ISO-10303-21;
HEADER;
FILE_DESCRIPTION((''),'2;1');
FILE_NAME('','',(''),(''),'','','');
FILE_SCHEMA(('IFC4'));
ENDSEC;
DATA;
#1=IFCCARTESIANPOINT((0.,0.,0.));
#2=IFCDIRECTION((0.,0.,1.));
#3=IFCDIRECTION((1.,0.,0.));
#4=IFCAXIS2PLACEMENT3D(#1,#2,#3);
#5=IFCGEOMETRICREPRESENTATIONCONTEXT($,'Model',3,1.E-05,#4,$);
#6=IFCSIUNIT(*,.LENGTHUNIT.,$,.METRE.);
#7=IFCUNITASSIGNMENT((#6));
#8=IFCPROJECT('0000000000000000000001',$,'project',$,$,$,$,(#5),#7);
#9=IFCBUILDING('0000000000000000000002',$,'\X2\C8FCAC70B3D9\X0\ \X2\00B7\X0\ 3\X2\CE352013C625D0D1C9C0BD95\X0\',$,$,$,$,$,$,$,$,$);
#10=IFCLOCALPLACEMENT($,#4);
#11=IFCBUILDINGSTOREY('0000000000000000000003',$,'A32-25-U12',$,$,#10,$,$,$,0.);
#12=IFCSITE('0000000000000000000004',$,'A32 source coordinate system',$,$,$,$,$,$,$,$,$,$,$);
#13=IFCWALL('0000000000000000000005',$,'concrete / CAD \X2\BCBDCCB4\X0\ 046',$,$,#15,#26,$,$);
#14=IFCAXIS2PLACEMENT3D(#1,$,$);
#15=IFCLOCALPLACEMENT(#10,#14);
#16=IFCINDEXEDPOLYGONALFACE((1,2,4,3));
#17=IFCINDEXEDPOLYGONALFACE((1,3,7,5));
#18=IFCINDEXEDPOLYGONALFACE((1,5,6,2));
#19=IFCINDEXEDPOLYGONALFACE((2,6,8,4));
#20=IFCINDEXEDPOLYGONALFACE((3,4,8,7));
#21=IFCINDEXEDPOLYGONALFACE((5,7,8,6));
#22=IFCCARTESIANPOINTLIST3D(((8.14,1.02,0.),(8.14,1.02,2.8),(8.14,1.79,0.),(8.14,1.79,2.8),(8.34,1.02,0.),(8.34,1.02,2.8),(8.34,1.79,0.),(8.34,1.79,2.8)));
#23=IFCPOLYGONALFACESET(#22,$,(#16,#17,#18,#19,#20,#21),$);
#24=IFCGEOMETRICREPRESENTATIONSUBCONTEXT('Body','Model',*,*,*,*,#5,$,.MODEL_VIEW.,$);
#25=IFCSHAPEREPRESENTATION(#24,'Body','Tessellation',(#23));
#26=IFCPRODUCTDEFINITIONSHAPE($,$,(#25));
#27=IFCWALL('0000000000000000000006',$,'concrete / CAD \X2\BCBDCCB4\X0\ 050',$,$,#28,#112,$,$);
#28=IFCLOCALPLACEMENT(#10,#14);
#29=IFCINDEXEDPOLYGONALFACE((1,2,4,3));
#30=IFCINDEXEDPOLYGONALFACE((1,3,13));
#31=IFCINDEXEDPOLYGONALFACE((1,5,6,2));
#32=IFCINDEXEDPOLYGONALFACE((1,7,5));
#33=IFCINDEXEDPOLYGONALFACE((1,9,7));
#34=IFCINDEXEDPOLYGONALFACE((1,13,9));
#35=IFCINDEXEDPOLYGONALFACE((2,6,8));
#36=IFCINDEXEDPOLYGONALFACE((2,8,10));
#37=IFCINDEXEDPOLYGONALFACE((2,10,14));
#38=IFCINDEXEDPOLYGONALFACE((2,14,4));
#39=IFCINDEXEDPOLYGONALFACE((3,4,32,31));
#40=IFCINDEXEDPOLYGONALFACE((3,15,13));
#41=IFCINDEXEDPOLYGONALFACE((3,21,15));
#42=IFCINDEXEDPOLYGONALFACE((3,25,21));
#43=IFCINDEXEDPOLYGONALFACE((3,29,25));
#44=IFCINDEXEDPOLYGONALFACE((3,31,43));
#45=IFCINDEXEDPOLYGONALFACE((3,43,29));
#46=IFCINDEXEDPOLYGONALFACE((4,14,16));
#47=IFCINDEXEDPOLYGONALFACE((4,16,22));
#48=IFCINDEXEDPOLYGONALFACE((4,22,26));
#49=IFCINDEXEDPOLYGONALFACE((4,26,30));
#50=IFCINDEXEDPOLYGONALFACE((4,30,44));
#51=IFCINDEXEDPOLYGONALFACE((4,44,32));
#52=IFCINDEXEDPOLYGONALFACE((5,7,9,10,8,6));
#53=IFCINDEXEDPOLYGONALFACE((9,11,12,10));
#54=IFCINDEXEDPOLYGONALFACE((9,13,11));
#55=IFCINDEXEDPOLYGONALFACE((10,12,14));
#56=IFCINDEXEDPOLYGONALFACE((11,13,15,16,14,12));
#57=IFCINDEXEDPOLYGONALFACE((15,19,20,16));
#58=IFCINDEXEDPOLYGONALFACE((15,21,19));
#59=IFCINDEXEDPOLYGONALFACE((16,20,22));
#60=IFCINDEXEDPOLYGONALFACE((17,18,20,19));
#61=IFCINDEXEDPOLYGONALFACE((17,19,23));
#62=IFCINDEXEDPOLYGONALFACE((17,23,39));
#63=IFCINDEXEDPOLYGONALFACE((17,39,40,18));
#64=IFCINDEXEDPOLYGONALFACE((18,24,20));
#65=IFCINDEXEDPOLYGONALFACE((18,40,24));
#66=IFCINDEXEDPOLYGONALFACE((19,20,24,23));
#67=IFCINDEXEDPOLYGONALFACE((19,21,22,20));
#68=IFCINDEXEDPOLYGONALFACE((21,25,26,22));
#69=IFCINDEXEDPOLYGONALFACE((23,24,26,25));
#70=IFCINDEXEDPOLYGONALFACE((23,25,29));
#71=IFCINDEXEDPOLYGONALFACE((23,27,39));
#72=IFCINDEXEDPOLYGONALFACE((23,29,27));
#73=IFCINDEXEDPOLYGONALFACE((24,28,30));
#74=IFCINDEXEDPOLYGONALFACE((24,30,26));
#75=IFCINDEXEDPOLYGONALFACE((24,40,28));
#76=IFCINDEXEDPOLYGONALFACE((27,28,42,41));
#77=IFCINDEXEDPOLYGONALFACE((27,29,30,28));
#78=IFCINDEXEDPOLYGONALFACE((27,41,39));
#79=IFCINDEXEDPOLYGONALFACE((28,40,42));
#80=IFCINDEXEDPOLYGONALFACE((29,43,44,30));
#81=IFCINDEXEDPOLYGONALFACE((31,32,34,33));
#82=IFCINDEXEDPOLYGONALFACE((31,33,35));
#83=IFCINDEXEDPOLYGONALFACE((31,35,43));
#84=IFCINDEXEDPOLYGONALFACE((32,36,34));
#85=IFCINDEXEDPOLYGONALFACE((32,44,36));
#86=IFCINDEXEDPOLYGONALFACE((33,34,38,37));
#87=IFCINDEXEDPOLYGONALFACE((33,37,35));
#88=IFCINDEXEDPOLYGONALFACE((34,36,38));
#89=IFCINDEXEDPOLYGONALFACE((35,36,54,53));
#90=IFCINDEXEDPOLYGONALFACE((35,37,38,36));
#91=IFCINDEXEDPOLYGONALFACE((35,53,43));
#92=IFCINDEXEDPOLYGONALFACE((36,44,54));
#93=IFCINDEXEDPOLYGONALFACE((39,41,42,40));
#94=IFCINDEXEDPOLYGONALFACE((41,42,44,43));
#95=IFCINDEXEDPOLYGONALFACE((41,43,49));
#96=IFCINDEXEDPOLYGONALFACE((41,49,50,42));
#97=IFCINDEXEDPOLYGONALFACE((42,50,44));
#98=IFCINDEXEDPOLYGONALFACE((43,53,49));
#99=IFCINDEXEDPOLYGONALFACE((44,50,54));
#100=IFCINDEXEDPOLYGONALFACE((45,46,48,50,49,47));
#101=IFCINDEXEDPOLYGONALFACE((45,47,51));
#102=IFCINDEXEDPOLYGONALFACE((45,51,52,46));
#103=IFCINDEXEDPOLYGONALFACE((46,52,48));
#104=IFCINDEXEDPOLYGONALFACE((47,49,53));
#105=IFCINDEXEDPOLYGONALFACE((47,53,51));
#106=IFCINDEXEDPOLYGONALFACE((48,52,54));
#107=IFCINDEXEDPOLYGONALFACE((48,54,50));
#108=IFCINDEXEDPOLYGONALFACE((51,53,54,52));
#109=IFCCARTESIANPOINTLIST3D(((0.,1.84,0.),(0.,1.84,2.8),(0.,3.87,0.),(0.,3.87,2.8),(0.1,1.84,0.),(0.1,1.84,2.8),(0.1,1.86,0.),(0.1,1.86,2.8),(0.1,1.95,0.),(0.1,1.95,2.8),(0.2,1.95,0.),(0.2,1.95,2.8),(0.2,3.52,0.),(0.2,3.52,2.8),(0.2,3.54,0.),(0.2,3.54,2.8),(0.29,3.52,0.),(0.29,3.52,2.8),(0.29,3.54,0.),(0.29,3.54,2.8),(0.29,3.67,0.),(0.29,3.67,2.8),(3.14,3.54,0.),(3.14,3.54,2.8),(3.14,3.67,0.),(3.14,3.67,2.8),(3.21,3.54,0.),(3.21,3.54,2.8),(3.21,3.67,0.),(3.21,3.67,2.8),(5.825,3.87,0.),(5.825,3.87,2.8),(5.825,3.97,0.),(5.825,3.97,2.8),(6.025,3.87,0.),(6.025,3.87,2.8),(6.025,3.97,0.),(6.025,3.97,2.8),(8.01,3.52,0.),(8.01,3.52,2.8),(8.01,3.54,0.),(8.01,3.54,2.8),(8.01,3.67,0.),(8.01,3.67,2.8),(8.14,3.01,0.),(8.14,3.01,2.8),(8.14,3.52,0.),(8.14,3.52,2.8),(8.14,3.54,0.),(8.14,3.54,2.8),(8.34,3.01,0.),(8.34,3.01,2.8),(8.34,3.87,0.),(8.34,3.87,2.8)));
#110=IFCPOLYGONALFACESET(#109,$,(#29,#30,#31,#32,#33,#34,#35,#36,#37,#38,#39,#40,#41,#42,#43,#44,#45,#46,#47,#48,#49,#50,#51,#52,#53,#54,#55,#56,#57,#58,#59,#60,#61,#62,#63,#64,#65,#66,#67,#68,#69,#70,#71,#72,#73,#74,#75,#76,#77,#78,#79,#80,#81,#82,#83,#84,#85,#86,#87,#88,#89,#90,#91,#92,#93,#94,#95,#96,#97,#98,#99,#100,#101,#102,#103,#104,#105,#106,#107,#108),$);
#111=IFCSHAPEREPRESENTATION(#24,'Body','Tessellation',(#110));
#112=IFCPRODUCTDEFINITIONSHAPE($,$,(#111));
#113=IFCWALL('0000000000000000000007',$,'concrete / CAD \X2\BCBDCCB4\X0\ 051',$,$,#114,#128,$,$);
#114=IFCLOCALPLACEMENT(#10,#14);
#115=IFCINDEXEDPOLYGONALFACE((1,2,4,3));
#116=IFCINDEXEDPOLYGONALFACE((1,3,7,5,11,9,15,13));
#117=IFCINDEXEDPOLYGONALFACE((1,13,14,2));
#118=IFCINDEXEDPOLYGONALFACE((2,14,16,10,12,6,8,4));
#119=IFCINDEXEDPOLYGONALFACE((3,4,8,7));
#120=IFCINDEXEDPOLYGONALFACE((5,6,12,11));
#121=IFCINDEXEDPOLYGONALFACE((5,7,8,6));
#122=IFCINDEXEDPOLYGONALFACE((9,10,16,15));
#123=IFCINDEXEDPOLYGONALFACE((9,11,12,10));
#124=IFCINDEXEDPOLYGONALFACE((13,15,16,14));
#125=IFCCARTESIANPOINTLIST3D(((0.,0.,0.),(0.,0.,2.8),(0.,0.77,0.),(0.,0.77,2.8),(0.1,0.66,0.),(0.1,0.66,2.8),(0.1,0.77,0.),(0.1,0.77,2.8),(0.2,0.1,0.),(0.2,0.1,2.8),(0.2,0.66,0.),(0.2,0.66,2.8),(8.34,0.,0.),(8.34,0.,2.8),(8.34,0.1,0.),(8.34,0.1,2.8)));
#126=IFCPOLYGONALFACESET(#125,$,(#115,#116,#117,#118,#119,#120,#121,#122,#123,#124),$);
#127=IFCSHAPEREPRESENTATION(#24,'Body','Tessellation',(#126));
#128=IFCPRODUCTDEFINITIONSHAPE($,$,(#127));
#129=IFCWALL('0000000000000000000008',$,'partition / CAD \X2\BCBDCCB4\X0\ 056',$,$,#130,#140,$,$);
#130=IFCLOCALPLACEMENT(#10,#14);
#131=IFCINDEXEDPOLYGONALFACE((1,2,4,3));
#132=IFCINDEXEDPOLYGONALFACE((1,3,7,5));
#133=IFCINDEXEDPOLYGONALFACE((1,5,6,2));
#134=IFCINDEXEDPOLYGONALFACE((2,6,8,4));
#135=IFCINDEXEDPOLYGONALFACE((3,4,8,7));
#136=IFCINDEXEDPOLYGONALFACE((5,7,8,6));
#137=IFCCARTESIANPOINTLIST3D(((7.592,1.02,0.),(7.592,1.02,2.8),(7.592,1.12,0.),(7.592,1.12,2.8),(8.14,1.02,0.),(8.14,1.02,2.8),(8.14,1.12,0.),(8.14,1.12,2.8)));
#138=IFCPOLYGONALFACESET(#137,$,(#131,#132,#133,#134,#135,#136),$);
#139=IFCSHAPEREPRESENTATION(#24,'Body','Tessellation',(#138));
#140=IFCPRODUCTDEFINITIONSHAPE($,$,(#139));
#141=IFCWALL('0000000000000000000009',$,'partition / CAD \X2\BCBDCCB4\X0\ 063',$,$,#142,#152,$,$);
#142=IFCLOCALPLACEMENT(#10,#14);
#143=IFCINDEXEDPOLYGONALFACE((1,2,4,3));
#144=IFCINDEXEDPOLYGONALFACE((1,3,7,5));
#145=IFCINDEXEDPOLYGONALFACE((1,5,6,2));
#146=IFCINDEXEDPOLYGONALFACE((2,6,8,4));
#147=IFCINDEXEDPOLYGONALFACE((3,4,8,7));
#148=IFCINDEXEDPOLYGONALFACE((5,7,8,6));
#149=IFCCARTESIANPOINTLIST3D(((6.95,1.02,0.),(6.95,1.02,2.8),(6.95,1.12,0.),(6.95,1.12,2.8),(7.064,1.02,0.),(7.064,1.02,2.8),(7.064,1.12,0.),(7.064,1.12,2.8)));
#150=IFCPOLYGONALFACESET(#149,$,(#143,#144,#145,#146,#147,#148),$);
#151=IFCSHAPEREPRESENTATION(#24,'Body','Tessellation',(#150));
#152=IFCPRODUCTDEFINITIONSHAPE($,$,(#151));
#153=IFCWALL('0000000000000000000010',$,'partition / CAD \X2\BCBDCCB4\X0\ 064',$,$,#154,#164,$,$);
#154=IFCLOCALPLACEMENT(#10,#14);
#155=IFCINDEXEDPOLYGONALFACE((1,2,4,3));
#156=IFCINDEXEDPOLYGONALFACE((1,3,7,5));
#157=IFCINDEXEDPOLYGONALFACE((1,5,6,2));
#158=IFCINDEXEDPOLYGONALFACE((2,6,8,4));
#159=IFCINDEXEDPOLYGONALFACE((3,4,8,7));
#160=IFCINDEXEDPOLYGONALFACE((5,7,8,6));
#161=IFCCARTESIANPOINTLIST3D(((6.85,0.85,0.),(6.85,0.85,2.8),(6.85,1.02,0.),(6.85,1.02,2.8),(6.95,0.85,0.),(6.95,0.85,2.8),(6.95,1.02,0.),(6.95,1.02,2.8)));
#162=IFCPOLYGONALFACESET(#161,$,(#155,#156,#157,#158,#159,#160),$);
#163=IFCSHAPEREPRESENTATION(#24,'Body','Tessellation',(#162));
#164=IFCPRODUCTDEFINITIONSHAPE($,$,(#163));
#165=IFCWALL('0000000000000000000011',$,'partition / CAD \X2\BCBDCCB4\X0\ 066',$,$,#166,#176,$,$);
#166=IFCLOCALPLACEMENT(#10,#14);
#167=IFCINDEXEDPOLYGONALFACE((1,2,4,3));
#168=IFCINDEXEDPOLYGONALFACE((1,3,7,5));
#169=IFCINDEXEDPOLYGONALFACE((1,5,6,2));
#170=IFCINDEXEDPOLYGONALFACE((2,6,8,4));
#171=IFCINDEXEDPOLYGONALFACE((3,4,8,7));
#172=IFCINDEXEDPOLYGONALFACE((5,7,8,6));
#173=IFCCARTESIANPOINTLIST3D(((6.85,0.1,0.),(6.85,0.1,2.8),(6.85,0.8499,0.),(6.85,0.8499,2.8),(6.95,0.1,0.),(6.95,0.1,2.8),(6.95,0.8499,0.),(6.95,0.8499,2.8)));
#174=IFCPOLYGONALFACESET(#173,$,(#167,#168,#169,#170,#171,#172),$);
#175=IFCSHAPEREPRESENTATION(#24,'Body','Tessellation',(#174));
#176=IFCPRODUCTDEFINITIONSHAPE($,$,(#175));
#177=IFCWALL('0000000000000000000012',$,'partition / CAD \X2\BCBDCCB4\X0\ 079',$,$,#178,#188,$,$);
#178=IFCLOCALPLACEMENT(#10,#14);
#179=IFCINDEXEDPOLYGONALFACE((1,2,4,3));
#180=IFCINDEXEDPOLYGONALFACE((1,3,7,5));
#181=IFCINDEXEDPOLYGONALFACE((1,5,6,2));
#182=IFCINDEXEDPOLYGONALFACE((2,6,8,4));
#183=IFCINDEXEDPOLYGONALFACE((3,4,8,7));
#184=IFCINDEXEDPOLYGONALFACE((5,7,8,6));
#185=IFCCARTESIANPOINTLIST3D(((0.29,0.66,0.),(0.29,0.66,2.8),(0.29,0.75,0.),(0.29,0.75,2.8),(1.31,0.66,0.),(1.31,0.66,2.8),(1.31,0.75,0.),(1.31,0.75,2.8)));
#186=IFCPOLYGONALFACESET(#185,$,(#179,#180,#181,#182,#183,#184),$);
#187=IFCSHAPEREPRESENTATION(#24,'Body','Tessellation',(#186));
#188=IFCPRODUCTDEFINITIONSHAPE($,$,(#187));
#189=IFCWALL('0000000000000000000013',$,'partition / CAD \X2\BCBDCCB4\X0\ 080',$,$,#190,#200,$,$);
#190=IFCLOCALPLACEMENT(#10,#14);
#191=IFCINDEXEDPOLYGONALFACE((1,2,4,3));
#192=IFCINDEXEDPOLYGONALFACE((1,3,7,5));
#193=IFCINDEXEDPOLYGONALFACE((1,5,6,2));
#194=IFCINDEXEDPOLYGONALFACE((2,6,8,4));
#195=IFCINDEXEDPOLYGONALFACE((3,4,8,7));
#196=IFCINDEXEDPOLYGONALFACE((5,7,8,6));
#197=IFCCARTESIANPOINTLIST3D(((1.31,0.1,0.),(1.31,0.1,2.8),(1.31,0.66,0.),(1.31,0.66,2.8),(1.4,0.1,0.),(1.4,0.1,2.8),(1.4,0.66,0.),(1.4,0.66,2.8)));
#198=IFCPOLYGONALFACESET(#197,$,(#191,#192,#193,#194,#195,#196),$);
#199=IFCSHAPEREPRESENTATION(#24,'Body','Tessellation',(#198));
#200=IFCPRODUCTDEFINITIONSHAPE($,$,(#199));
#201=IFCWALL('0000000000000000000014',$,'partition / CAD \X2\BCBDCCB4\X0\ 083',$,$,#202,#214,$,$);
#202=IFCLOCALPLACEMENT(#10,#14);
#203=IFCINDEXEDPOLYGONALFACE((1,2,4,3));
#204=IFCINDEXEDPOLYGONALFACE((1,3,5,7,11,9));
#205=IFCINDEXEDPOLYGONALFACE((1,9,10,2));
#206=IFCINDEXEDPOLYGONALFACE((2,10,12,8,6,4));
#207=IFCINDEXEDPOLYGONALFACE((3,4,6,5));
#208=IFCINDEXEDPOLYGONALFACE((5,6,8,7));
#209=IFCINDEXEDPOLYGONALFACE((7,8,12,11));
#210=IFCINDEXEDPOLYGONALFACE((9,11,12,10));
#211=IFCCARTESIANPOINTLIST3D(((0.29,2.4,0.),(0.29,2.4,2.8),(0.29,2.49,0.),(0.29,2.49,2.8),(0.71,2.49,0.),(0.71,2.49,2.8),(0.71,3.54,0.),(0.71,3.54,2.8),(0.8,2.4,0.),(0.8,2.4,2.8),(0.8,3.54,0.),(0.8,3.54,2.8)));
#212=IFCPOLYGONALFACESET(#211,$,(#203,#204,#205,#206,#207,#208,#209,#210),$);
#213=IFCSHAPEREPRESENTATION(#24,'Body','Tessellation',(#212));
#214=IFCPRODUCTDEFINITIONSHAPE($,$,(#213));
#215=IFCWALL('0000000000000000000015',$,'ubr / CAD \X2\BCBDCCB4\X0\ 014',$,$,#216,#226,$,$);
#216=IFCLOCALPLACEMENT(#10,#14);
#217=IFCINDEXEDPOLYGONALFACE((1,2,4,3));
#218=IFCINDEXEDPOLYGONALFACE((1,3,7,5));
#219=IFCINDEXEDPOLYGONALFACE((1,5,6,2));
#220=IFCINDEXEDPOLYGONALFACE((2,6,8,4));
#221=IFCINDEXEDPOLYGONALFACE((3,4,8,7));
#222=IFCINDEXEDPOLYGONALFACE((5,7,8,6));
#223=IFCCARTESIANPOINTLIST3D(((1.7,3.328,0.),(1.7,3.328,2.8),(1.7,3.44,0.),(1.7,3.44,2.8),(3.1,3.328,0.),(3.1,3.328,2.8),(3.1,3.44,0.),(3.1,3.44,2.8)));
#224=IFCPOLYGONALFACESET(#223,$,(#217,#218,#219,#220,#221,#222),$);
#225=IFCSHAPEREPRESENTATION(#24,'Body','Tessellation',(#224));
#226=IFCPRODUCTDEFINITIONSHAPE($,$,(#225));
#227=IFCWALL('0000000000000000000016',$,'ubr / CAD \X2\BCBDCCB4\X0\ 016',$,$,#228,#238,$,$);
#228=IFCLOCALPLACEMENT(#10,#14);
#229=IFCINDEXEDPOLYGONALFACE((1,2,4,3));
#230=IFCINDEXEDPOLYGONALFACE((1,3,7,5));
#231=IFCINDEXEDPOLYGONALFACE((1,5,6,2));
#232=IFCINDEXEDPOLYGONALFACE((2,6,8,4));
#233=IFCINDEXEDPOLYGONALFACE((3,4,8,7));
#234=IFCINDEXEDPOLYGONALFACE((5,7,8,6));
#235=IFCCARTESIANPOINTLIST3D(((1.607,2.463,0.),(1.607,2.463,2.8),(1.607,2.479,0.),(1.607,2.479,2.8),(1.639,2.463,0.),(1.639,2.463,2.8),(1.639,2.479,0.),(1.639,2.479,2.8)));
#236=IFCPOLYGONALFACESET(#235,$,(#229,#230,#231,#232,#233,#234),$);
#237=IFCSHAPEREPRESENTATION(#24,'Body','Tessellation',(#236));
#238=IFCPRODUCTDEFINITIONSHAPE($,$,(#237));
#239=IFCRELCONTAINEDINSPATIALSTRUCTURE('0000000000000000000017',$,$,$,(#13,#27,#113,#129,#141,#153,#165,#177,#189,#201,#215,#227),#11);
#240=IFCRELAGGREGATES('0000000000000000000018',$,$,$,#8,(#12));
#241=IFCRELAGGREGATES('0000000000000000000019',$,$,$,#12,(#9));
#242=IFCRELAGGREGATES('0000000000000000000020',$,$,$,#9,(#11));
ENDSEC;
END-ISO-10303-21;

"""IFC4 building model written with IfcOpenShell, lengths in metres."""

from ifc_helpers import new_model, si_unit, origin, origin_with_axes, place, context, subcontext, project, spatial, polyline, outline, extrude, element, save


model = new_model("IFC4")

# Units and contexts
model_context = context("Model", 3, precision=1e-05, world=origin_with_axes())
body_context = subcontext(model_context, "Body", "Model", "MODEL_VIEW")
ifc_project = project(units=[si_unit("LENGTHUNIT", "METRE")], contexts=[model_context])

# Site, building, storey
site = spatial("IfcSite", under=ifc_project, Name="A32 source coordinate system")
building = spatial("IfcBuilding", under=site, Name="주거동 · 3층–옥탑지붕")
storey_placement = place(None, origin_with_axes())
storey = spatial("IfcBuildingStorey", under=building, at=storey_placement, Name="A32-25-U12", Elevation=0.0)

# Walls
wall_1_placement = place(storey_placement, origin_with_axes())
element("IfcWall", 1, at=wall_1_placement, inside=storey, Name="concrete / CAD 벽체 046", context=body_context, shape_type="SweptSolid", body=[
    extrude(outline(polyline([(8.14, 1.02), (8.14, 1.79), (8.34, 1.79), (8.34, 1.02), (8.14, 1.02)])), origin(), (0.0, 0.0, 1.0), 2.8),
])
wall_2_placement = place(storey_placement, origin_with_axes())
element("IfcWall", 2, at=wall_2_placement, inside=storey, Name="concrete / CAD 벽체 050", context=body_context, shape_type="SweptSolid", body=[
    extrude(outline(polyline([(8.01, 3.52), (0.29, 3.52), (0.29, 3.54), (0.2, 3.54), (0.2, 3.52), (0.2, 1.95), (0.1, 1.95), (0.1, 1.86), (0.1, 1.84), (0.0, 1.84), (0.0, 3.87), (5.825, 3.87), (5.825, 3.97), (6.025, 3.97), (6.025, 3.87), (8.34, 3.87), (8.34, 3.01), (8.14, 3.01), (8.14, 3.52), (8.14, 3.54), (8.01, 3.54), (8.01, 3.52)]), holes=[polyline([(3.14, 3.54), (3.14, 3.67), (0.29, 3.67), (0.29, 3.54), (3.14, 3.54)]), polyline([(8.01, 3.67), (3.21, 3.67), (3.21, 3.54), (8.01, 3.54), (8.01, 3.67)])]), origin(), (0.0, 0.0, 1.0), 2.8),
])
wall_3_placement = place(storey_placement, origin_with_axes())
element("IfcWall", 3, at=wall_3_placement, inside=storey, Name="concrete / CAD 벽체 051", context=body_context, shape_type="SweptSolid", body=[
    extrude(outline(polyline([(0.2, 0.1), (8.34, 0.1), (8.34, 0.0), (8.34, 0.0), (8.34, 0.0), (0.0, 0.0), (0.0, 0.77), (0.1, 0.77), (0.1, 0.66), (0.2, 0.66), (0.2, 0.1)])), origin(), (0.0, 0.0, 1.0), 2.8),
])
wall_4_placement = place(storey_placement, origin_with_axes())
element("IfcWall", 4, at=wall_4_placement, inside=storey, Name="partition / CAD 벽체 056", context=body_context, shape_type="SweptSolid", body=[
    extrude(outline(polyline([(7.592, 1.12), (8.14, 1.12), (8.14, 1.02), (7.592, 1.02), (7.592, 1.12)])), origin(), (0.0, 0.0, 1.0), 2.8),
])
wall_5_placement = place(storey_placement, origin_with_axes())
element("IfcWall", 5, at=wall_5_placement, inside=storey, Name="partition / CAD 벽체 063", context=body_context, shape_type="SweptSolid", body=[
    extrude(outline(polyline([(6.95, 1.12), (7.064, 1.12), (7.064, 1.02), (6.95, 1.02), (6.95, 1.12)])), origin(), (0.0, 0.0, 1.0), 2.8),
])
wall_6_placement = place(storey_placement, origin_with_axes())
element("IfcWall", 6, at=wall_6_placement, inside=storey, Name="partition / CAD 벽체 064", context=body_context, shape_type="SweptSolid", body=[
    extrude(outline(polyline([(6.95, 0.85), (6.85, 0.85), (6.85, 1.02), (6.95, 1.02), (6.95, 0.85)])), origin(), (0.0, 0.0, 1.0), 2.8),
])
wall_7_placement = place(storey_placement, origin_with_axes())
element("IfcWall", 7, at=wall_7_placement, inside=storey, Name="partition / CAD 벽체 066", context=body_context, shape_type="SweptSolid", body=[
    extrude(outline(polyline([(6.85, 0.8499), (6.95, 0.8499), (6.95, 0.1), (6.85, 0.1), (6.85, 0.8499)])), origin(), (0.0, 0.0, 1.0), 2.8),
])
wall_8_placement = place(storey_placement, origin_with_axes())
element("IfcWall", 8, at=wall_8_placement, inside=storey, Name="partition / CAD 벽체 079", context=body_context, shape_type="SweptSolid", body=[
    extrude(outline(polyline([(0.29, 0.75), (1.31, 0.75), (1.31, 0.66), (0.29, 0.66), (0.29, 0.75)])), origin(), (0.0, 0.0, 1.0), 2.8),
])
wall_9_placement = place(storey_placement, origin_with_axes())
element("IfcWall", 9, at=wall_9_placement, inside=storey, Name="partition / CAD 벽체 080", context=body_context, shape_type="SweptSolid", body=[
    extrude(outline(polyline([(1.4, 0.66), (1.4, 0.1), (1.31, 0.1), (1.31, 0.66), (1.4, 0.66)])), origin(), (0.0, 0.0, 1.0), 2.8),
])
wall_10_placement = place(storey_placement, origin_with_axes())
element("IfcWall", 10, at=wall_10_placement, inside=storey, Name="partition / CAD 벽체 083", context=body_context, shape_type="SweptSolid", body=[
    extrude(outline(polyline([(0.71, 2.49), (0.71, 3.54), (0.8, 3.54), (0.8, 2.4), (0.29, 2.4), (0.29, 2.49), (0.71, 2.49)])), origin(), (0.0, 0.0, 1.0), 2.8),
])
wall_11_placement = place(storey_placement, origin_with_axes())
element("IfcWall", 11, at=wall_11_placement, inside=storey, Name="ubr / CAD 벽체 014", context=body_context, shape_type="SweptSolid", body=[
    extrude(outline(polyline([(3.1, 3.44), (3.1, 3.328), (1.7, 3.328), (1.7, 3.44), (3.1, 3.44)])), origin(), (0.0, 0.0, 1.0), 2.8),
])
wall_12_placement = place(storey_placement, origin_with_axes())
element("IfcWall", 12, at=wall_12_placement, inside=storey, Name="ubr / CAD 벽체 016", context=body_context, shape_type="SweptSolid", body=[
    extrude(outline(polyline([(1.639, 2.479), (1.639, 2.463), (1.607, 2.463), (1.607, 2.479), (1.639, 2.479)])), origin(), (0.0, 0.0, 1.0), 2.8),
])

save(model, "model.ifc")
